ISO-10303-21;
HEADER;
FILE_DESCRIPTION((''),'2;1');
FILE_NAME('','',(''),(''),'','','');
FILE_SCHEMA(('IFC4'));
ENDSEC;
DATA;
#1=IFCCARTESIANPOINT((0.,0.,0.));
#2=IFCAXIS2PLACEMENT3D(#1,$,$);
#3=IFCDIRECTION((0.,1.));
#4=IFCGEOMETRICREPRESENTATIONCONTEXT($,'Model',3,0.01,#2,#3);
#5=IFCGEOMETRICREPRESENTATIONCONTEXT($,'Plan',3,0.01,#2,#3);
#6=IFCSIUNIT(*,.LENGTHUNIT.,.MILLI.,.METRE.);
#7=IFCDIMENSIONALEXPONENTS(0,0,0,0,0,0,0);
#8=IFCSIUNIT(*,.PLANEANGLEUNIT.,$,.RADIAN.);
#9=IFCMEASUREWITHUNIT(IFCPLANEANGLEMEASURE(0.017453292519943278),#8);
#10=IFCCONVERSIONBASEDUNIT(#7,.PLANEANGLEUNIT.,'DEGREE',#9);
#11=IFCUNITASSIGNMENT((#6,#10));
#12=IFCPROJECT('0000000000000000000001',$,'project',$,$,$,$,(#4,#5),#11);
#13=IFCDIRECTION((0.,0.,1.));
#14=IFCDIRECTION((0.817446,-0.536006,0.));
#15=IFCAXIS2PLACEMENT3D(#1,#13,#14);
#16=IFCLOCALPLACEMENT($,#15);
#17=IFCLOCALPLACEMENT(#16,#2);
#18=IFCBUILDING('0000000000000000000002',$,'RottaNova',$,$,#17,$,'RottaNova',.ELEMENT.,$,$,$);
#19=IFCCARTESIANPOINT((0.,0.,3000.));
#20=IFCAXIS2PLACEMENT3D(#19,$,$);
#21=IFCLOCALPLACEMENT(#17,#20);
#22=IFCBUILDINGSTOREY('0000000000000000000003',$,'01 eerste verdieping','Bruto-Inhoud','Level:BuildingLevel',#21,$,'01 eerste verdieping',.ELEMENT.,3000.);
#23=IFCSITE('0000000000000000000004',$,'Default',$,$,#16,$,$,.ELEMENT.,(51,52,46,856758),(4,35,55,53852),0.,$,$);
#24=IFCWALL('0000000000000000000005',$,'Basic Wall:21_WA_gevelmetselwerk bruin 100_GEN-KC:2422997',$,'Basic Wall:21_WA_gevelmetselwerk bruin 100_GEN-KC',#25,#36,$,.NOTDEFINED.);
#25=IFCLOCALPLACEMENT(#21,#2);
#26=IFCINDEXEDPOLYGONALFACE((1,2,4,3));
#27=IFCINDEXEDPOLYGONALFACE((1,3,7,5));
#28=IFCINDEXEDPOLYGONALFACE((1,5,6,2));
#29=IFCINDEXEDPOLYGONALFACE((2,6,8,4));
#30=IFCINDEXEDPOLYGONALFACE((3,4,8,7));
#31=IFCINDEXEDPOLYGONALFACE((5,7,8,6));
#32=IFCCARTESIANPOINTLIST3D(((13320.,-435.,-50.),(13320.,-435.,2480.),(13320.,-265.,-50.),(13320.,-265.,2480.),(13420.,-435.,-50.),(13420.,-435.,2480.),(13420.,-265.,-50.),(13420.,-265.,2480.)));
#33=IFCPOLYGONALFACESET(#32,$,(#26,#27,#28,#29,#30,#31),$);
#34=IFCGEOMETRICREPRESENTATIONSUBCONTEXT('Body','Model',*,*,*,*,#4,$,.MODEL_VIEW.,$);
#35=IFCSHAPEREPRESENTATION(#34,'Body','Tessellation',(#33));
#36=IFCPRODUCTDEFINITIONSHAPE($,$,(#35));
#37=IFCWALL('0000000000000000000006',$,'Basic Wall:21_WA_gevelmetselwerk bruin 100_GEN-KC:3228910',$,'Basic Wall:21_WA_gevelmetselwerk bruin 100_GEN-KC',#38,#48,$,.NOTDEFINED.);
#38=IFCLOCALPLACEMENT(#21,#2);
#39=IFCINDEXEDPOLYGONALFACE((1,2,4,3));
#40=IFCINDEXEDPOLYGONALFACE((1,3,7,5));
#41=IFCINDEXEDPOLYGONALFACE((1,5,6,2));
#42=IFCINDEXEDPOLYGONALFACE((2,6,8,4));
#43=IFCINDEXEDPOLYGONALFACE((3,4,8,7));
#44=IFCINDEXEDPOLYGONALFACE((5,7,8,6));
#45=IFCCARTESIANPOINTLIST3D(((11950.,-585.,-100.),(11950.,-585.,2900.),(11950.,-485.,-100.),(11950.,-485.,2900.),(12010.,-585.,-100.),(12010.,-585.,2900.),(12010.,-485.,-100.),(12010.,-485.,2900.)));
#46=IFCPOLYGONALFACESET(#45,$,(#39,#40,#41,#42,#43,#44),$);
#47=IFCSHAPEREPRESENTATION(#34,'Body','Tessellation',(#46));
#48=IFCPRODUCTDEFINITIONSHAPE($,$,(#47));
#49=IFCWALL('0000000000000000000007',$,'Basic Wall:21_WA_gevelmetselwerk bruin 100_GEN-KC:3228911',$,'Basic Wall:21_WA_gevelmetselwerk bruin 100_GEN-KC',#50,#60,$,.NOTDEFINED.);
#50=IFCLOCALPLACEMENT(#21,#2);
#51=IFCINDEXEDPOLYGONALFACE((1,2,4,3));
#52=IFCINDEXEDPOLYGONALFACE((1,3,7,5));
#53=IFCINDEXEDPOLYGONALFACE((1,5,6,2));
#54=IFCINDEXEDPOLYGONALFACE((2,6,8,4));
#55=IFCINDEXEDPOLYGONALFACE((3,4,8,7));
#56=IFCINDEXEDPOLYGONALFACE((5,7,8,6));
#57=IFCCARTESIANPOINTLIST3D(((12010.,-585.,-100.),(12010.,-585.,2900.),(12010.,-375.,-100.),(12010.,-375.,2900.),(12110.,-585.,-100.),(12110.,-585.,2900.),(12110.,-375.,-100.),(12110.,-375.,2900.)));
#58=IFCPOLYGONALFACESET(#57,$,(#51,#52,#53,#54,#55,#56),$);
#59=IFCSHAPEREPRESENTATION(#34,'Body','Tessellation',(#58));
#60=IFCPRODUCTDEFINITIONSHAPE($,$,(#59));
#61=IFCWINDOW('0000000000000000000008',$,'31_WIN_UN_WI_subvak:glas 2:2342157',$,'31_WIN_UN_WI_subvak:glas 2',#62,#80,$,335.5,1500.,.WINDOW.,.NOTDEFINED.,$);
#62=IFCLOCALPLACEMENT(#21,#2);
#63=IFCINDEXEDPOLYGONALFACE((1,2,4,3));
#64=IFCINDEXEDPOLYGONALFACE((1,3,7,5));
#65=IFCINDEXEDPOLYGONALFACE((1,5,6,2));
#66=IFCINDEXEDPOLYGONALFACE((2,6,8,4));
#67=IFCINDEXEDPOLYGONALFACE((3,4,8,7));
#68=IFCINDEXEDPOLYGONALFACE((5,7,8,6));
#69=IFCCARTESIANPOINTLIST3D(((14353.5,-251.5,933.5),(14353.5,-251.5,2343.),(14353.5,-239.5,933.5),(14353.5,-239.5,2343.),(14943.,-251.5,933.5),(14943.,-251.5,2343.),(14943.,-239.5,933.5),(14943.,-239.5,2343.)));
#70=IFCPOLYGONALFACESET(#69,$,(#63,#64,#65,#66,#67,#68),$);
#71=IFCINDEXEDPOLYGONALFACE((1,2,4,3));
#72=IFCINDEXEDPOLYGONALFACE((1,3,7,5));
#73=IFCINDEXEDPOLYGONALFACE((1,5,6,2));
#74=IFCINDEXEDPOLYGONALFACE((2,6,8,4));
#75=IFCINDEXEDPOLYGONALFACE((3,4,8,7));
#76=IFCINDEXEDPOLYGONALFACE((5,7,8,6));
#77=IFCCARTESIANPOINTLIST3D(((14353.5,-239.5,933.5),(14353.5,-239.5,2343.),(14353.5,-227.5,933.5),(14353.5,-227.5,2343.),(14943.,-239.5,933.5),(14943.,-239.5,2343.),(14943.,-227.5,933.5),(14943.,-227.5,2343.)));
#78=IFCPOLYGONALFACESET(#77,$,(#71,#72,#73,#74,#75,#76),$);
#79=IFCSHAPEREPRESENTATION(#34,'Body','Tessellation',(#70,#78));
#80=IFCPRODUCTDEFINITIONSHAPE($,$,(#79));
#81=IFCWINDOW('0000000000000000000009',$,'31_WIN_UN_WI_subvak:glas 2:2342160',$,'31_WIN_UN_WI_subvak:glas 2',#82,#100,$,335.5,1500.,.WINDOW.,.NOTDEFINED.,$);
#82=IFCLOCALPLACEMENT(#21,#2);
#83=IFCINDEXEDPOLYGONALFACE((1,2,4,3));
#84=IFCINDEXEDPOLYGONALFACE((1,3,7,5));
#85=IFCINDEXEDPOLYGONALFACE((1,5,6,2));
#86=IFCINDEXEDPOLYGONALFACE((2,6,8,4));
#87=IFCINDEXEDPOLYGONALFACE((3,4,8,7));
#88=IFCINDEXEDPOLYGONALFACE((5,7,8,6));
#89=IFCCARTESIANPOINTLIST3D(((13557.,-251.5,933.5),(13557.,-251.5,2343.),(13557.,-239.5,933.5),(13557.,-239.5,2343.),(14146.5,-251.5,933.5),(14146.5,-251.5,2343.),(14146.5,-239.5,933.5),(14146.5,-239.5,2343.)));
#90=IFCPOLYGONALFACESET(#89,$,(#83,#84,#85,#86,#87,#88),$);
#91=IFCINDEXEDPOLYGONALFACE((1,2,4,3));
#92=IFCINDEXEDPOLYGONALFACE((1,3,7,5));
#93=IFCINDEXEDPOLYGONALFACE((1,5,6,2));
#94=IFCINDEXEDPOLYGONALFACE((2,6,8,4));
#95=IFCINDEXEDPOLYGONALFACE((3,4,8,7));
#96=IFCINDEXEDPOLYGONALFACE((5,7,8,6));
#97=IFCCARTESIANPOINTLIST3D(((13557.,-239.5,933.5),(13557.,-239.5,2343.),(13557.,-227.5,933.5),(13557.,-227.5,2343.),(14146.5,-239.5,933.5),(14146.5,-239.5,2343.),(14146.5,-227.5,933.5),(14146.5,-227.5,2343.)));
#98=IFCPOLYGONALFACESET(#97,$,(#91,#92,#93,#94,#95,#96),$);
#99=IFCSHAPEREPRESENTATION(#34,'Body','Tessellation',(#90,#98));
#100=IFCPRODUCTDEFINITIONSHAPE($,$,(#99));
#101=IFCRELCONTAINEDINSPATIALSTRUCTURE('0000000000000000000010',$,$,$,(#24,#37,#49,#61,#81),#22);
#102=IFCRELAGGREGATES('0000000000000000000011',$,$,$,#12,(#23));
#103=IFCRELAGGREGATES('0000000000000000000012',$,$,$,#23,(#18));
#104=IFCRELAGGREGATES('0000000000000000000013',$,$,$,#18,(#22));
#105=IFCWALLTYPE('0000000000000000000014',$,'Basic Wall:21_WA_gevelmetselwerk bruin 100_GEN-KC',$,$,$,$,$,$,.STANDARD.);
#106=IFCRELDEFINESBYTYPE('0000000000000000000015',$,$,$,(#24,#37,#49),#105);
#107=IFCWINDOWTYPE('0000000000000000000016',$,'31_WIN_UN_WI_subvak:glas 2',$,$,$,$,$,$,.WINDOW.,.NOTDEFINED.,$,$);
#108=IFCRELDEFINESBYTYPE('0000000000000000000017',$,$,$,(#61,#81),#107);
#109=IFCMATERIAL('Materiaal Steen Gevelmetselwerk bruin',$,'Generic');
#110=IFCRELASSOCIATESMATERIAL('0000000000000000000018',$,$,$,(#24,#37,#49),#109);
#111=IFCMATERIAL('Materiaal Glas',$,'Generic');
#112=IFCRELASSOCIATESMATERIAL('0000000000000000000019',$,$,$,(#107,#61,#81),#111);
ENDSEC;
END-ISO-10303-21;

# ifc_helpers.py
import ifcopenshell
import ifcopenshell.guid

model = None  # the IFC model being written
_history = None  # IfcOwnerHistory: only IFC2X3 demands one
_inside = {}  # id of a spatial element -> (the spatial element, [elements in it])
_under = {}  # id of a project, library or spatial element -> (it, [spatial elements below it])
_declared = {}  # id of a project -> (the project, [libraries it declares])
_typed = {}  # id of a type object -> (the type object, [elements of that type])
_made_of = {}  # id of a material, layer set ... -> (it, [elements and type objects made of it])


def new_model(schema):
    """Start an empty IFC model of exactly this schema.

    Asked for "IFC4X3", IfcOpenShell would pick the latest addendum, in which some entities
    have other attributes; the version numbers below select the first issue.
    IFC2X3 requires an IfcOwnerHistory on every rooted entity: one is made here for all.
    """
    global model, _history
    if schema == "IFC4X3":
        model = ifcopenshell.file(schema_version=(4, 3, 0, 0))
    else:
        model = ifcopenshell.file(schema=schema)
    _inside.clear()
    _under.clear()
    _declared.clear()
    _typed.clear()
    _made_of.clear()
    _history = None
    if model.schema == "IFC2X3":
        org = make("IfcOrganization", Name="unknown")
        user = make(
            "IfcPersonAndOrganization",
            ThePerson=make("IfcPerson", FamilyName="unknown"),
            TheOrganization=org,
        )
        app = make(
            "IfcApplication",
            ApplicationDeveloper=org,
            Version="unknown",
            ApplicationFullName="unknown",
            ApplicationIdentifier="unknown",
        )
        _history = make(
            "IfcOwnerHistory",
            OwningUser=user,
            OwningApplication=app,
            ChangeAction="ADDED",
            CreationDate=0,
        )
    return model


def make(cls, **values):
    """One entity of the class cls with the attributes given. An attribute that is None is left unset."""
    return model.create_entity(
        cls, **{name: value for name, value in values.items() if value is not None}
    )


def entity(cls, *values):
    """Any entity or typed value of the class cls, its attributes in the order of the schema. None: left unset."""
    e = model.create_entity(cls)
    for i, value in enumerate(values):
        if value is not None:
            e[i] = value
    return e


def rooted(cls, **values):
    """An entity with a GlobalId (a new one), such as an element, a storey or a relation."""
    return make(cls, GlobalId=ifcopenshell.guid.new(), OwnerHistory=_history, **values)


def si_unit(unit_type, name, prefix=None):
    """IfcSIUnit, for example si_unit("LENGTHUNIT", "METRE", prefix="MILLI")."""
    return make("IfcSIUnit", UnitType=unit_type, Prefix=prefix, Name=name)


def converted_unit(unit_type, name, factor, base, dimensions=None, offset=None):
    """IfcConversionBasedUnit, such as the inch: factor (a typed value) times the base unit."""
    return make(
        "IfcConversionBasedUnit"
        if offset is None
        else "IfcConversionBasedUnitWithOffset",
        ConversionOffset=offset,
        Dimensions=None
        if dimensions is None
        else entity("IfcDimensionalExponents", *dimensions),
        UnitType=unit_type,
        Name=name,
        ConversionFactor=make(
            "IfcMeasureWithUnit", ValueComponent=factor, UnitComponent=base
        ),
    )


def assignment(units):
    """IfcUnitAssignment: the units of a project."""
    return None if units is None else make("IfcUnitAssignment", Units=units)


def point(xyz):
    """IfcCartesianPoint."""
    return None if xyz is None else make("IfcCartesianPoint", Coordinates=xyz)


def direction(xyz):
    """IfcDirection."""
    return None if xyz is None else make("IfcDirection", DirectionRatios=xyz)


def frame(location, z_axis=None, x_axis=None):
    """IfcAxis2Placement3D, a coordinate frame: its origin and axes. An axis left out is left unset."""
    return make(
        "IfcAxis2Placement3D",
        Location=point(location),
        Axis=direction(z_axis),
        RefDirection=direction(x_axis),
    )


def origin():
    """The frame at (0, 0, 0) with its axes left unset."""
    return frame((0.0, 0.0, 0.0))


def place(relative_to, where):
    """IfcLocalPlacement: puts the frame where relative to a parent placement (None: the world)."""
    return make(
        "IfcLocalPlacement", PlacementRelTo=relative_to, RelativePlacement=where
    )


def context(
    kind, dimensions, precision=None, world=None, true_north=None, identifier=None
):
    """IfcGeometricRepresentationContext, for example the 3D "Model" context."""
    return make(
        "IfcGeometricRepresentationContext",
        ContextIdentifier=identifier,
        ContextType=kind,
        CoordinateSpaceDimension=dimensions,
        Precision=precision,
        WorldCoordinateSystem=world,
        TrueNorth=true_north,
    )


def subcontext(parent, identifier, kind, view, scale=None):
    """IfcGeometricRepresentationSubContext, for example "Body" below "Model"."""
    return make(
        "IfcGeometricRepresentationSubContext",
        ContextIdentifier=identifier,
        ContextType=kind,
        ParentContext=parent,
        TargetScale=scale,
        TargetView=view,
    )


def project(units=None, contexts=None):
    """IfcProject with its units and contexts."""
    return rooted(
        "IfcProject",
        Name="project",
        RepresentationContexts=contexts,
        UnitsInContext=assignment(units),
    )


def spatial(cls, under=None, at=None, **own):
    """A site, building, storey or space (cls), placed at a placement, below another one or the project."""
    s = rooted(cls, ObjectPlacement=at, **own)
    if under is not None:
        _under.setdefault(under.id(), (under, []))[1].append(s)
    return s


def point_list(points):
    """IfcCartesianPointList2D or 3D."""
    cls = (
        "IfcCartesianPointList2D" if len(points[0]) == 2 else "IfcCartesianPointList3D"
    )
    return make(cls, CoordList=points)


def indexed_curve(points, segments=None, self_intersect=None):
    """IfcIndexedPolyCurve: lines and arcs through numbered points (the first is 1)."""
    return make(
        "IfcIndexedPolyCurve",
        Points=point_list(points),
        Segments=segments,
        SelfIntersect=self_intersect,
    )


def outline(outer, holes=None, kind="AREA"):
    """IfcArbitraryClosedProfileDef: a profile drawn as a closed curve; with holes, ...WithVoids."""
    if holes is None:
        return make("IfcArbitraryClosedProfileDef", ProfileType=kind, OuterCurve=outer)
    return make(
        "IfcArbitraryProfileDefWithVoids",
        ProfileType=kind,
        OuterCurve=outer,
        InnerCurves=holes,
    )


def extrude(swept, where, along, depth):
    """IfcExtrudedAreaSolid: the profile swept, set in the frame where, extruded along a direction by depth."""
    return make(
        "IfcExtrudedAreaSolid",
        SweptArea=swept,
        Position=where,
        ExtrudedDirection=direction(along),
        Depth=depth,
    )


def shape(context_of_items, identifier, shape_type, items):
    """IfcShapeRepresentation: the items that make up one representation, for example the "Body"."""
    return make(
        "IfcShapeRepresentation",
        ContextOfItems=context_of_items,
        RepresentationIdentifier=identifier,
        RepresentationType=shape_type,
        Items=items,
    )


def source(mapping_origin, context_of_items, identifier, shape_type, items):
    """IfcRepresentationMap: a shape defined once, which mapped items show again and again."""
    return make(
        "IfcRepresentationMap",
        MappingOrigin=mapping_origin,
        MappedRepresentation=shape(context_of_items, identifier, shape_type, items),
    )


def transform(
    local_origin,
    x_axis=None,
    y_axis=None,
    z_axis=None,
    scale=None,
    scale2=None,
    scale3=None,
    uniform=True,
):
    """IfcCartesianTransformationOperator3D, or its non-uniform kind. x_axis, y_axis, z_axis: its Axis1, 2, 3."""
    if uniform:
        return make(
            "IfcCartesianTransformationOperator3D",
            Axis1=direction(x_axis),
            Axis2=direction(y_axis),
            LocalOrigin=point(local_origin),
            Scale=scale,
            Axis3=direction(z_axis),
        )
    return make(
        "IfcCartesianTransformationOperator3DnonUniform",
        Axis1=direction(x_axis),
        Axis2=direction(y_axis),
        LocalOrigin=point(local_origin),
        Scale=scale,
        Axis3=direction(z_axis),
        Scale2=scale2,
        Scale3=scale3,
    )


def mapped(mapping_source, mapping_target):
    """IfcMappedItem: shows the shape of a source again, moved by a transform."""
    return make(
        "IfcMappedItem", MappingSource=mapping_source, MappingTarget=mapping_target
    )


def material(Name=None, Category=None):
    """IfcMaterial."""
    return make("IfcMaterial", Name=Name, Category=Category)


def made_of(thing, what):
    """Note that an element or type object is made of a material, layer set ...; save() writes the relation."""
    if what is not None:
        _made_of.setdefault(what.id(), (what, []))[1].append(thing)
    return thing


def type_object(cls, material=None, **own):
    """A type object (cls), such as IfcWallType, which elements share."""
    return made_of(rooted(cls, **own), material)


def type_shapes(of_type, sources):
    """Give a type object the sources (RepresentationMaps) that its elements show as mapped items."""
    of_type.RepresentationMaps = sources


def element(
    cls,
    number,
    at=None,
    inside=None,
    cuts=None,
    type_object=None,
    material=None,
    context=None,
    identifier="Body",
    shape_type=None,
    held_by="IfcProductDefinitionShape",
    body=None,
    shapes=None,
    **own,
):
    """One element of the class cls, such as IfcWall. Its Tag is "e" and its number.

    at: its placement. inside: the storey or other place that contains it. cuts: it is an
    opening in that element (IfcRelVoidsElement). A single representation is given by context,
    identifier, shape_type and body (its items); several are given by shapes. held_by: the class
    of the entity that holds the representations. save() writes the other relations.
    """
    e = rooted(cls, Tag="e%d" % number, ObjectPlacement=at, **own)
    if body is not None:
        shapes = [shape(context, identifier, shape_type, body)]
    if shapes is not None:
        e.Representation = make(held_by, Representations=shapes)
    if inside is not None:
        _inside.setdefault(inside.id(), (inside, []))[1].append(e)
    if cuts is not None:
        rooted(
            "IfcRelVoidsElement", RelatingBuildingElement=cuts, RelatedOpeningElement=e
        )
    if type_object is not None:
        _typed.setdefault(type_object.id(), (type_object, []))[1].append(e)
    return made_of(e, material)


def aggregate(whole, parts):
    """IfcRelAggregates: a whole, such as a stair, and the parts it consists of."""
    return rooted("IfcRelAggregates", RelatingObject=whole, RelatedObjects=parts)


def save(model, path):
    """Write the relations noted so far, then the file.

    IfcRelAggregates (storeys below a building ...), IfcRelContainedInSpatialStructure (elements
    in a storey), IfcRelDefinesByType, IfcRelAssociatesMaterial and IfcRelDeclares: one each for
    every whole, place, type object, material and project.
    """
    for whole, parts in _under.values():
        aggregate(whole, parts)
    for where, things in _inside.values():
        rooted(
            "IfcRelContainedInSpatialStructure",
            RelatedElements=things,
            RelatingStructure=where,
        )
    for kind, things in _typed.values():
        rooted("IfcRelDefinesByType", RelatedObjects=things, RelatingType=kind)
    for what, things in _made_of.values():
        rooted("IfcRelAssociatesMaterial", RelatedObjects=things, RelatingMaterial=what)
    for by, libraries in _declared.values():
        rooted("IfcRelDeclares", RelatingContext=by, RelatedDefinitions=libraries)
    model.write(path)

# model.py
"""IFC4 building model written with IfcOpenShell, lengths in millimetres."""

from ifc_helpers import new_model, entity, si_unit, converted_unit, direction, frame, origin, place, context, subcontext, project, spatial, indexed_curve, outline, extrude, source, transform, mapped, material, type_object, type_shapes, element, save


model = new_model("IFC4")

# Units and contexts
model_context = context("Model", 3, precision=0.01, world=origin(), true_north=direction((0.0, 1.0)))
plan_context = context("Plan", 3, precision=0.01, world=origin(), true_north=direction((0.0, 1.0)))
body_context = subcontext(model_context, "Body", "Model", "MODEL_VIEW")
ifc_project = project(units=[si_unit("LENGTHUNIT", "METRE", prefix="MILLI"), converted_unit("PLANEANGLEUNIT", "DEGREE", entity("IfcPlaneAngleMeasure", 0.017453292519943278), si_unit("PLANEANGLEUNIT", "RADIAN"), dimensions=[0, 0, 0, 0, 0, 0, 0])], contexts=[model_context, plan_context])

# Site, building, storey
site_placement = place(None, frame((0.0, 0.0, 0.0), z_axis=(0.0, 0.0, 1.0), x_axis=(0.817446, -0.536006, 0.0)))
site = spatial("IfcSite", under=ifc_project, at=site_placement, Name="Default", CompositionType="ELEMENT", RefLatitude=(51, 52, 46, 856758), RefLongitude=(4, 35, 55, 53852), RefElevation=0.0)
building_placement = place(site_placement, origin())
building = spatial("IfcBuilding", under=site, at=building_placement, Name="RottaNova", LongName="RottaNova", CompositionType="ELEMENT")
storey_placement = place(building_placement, frame((0.0, 0.0, 3000.0)))
storey = spatial("IfcBuildingStorey", under=building, at=storey_placement, Name="01 eerste verdieping", Description="Bruto-Inhoud", ObjectType="Level:BuildingLevel", LongName="01 eerste verdieping", CompositionType="ELEMENT", Elevation=3000.0)

# Shared definitions
ifc_material_1 = material(Name="Materiaal Glas", Category="Generic")

# Walls
ifc_material_2 = material(Name="Materiaal Steen Gevelmetselwerk bruin", Category="Generic")
wall_type_1 = type_object("IfcWallType", Name="Basic Wall:21_WA_gevelmetselwerk bruin 100_GEN-KC", PredefinedType="STANDARD")
wall_1_placement = place(storey_placement, frame((13370.0, -265.0, -50.0), z_axis=(0.0, 0.0, 1.0), x_axis=(0.0, -1.0, 0.0)))
element("IfcWall", 1, at=wall_1_placement, inside=storey, type_object=wall_type_1, material=ifc_material_2, Name="Basic Wall:21_WA_gevelmetselwerk bruin 100_GEN-KC:2422997", ObjectType="Basic Wall:21_WA_gevelmetselwerk bruin 100_GEN-KC", PredefinedType="NOTDEFINED", context=body_context, shape_type="SweptSolid", body=[
    extrude(outline(indexed_curve([(170.0, 50.0), (0.0, 50.0), (0.0, -50.0), (170.0, -50.0), (170.0, 50.0)], self_intersect=False)), origin(), (0.0, 0.0, 1.0), 2530.0),
])
wall_2_placement = place(storey_placement, frame((12010.0, -535.0, -100.0), z_axis=(0.0, 0.0, 1.0), x_axis=(-1.0, 0.0, 0.0)))
element("IfcWall", 2, at=wall_2_placement, inside=storey, type_object=wall_type_1, material=ifc_material_2, Name="Basic Wall:21_WA_gevelmetselwerk bruin 100_GEN-KC:3228910", ObjectType="Basic Wall:21_WA_gevelmetselwerk bruin 100_GEN-KC", PredefinedType="NOTDEFINED", context=body_context, shape_type="SweptSolid", body=[
    extrude(outline(indexed_curve([(60.0, 50.0), (0.0, 50.0), (0.0, -50.0), (60.0, -50.0), (60.0, 50.0)], self_intersect=False)), origin(), (0.0, 0.0, 1.0), 3000.0),
])
wall_3_placement = place(storey_placement, frame((12060.0, -585.0, -100.0), z_axis=(0.0, 0.0, 1.0), x_axis=(0.0, 1.0, 0.0)))
element("IfcWall", 3, at=wall_3_placement, inside=storey, type_object=wall_type_1, material=ifc_material_2, Name="Basic Wall:21_WA_gevelmetselwerk bruin 100_GEN-KC:3228911", ObjectType="Basic Wall:21_WA_gevelmetselwerk bruin 100_GEN-KC", PredefinedType="NOTDEFINED", context=body_context, shape_type="SweptSolid", body=[
    extrude(outline(indexed_curve([(210.0, 50.0), (0.0, 50.0), (0.0, -50.0), (210.0, -50.0), (210.0, 50.0)], self_intersect=False)), origin(), (0.0, 0.0, 1.0), 3000.0),
])

# Windows
window_type = type_object("IfcWindowType", Name="31_WIN_UN_WI_subvak:glas 2", PartitioningType="NOTDEFINED", PredefinedType="WINDOW", material=ifc_material_1)
shared_shape_1 = source(origin(), body_context, "Body", "SweptSolid", [
    extrude(outline(indexed_curve([(-6.0, -294.7), (6.0, -294.7), (6.0, 294.7), (-6.0, 294.7), (-6.0, -294.7)], self_intersect=False)), frame((0.0, 6.0, 0.0), z_axis=(0.0, 0.0, 1.0), x_axis=(0.0, -1.0, 0.0)), (0.0, 0.0, 1.0), 1409.5),
    extrude(outline(indexed_curve([(-6.0, -294.8), (6.0, -294.8), (6.0, 294.8), (-6.0, 294.8), (-6.0, -294.8)], self_intersect=False)), frame((0.0, -6.0, 0.0), z_axis=(0.0, 0.0, 1.0), x_axis=(0.0, -1.0, 0.0)), (0.0, 0.0, 1.0), 1409.5),
])
type_shapes(window_type, [shared_shape_1])
for number, where, z_axis, x_axis, name in (
    (4, (14648.3, -239.5, 933.5), (0.0, 0.0, 1.0), (-1.0, 0.0, 0.0), "31_WIN_UN_WI_subvak:glas 2:2342157"),
    (5, (13851.8, -239.5, 933.5), (0.0, 0.0, 1.0), (-1.0, 0.0, 0.0), "31_WIN_UN_WI_subvak:glas 2:2342160"),
):
    element("IfcWindow", number, at=place(storey_placement, frame(where, z_axis=z_axis, x_axis=x_axis)), inside=storey, type_object=window_type, material=ifc_material_1, Name=name, ObjectType="31_WIN_UN_WI_subvak:glas 2", OverallHeight=335.5, OverallWidth=1500.0, PartitioningType="NOTDEFINED", PredefinedType="WINDOW", context=body_context, shape_type="MappedRepresentation", body=[
        mapped(shared_shape_1, transform((0.0, 0.0, 0.0), scale=1.0)),
    ])

save(model, "model.ifc")
